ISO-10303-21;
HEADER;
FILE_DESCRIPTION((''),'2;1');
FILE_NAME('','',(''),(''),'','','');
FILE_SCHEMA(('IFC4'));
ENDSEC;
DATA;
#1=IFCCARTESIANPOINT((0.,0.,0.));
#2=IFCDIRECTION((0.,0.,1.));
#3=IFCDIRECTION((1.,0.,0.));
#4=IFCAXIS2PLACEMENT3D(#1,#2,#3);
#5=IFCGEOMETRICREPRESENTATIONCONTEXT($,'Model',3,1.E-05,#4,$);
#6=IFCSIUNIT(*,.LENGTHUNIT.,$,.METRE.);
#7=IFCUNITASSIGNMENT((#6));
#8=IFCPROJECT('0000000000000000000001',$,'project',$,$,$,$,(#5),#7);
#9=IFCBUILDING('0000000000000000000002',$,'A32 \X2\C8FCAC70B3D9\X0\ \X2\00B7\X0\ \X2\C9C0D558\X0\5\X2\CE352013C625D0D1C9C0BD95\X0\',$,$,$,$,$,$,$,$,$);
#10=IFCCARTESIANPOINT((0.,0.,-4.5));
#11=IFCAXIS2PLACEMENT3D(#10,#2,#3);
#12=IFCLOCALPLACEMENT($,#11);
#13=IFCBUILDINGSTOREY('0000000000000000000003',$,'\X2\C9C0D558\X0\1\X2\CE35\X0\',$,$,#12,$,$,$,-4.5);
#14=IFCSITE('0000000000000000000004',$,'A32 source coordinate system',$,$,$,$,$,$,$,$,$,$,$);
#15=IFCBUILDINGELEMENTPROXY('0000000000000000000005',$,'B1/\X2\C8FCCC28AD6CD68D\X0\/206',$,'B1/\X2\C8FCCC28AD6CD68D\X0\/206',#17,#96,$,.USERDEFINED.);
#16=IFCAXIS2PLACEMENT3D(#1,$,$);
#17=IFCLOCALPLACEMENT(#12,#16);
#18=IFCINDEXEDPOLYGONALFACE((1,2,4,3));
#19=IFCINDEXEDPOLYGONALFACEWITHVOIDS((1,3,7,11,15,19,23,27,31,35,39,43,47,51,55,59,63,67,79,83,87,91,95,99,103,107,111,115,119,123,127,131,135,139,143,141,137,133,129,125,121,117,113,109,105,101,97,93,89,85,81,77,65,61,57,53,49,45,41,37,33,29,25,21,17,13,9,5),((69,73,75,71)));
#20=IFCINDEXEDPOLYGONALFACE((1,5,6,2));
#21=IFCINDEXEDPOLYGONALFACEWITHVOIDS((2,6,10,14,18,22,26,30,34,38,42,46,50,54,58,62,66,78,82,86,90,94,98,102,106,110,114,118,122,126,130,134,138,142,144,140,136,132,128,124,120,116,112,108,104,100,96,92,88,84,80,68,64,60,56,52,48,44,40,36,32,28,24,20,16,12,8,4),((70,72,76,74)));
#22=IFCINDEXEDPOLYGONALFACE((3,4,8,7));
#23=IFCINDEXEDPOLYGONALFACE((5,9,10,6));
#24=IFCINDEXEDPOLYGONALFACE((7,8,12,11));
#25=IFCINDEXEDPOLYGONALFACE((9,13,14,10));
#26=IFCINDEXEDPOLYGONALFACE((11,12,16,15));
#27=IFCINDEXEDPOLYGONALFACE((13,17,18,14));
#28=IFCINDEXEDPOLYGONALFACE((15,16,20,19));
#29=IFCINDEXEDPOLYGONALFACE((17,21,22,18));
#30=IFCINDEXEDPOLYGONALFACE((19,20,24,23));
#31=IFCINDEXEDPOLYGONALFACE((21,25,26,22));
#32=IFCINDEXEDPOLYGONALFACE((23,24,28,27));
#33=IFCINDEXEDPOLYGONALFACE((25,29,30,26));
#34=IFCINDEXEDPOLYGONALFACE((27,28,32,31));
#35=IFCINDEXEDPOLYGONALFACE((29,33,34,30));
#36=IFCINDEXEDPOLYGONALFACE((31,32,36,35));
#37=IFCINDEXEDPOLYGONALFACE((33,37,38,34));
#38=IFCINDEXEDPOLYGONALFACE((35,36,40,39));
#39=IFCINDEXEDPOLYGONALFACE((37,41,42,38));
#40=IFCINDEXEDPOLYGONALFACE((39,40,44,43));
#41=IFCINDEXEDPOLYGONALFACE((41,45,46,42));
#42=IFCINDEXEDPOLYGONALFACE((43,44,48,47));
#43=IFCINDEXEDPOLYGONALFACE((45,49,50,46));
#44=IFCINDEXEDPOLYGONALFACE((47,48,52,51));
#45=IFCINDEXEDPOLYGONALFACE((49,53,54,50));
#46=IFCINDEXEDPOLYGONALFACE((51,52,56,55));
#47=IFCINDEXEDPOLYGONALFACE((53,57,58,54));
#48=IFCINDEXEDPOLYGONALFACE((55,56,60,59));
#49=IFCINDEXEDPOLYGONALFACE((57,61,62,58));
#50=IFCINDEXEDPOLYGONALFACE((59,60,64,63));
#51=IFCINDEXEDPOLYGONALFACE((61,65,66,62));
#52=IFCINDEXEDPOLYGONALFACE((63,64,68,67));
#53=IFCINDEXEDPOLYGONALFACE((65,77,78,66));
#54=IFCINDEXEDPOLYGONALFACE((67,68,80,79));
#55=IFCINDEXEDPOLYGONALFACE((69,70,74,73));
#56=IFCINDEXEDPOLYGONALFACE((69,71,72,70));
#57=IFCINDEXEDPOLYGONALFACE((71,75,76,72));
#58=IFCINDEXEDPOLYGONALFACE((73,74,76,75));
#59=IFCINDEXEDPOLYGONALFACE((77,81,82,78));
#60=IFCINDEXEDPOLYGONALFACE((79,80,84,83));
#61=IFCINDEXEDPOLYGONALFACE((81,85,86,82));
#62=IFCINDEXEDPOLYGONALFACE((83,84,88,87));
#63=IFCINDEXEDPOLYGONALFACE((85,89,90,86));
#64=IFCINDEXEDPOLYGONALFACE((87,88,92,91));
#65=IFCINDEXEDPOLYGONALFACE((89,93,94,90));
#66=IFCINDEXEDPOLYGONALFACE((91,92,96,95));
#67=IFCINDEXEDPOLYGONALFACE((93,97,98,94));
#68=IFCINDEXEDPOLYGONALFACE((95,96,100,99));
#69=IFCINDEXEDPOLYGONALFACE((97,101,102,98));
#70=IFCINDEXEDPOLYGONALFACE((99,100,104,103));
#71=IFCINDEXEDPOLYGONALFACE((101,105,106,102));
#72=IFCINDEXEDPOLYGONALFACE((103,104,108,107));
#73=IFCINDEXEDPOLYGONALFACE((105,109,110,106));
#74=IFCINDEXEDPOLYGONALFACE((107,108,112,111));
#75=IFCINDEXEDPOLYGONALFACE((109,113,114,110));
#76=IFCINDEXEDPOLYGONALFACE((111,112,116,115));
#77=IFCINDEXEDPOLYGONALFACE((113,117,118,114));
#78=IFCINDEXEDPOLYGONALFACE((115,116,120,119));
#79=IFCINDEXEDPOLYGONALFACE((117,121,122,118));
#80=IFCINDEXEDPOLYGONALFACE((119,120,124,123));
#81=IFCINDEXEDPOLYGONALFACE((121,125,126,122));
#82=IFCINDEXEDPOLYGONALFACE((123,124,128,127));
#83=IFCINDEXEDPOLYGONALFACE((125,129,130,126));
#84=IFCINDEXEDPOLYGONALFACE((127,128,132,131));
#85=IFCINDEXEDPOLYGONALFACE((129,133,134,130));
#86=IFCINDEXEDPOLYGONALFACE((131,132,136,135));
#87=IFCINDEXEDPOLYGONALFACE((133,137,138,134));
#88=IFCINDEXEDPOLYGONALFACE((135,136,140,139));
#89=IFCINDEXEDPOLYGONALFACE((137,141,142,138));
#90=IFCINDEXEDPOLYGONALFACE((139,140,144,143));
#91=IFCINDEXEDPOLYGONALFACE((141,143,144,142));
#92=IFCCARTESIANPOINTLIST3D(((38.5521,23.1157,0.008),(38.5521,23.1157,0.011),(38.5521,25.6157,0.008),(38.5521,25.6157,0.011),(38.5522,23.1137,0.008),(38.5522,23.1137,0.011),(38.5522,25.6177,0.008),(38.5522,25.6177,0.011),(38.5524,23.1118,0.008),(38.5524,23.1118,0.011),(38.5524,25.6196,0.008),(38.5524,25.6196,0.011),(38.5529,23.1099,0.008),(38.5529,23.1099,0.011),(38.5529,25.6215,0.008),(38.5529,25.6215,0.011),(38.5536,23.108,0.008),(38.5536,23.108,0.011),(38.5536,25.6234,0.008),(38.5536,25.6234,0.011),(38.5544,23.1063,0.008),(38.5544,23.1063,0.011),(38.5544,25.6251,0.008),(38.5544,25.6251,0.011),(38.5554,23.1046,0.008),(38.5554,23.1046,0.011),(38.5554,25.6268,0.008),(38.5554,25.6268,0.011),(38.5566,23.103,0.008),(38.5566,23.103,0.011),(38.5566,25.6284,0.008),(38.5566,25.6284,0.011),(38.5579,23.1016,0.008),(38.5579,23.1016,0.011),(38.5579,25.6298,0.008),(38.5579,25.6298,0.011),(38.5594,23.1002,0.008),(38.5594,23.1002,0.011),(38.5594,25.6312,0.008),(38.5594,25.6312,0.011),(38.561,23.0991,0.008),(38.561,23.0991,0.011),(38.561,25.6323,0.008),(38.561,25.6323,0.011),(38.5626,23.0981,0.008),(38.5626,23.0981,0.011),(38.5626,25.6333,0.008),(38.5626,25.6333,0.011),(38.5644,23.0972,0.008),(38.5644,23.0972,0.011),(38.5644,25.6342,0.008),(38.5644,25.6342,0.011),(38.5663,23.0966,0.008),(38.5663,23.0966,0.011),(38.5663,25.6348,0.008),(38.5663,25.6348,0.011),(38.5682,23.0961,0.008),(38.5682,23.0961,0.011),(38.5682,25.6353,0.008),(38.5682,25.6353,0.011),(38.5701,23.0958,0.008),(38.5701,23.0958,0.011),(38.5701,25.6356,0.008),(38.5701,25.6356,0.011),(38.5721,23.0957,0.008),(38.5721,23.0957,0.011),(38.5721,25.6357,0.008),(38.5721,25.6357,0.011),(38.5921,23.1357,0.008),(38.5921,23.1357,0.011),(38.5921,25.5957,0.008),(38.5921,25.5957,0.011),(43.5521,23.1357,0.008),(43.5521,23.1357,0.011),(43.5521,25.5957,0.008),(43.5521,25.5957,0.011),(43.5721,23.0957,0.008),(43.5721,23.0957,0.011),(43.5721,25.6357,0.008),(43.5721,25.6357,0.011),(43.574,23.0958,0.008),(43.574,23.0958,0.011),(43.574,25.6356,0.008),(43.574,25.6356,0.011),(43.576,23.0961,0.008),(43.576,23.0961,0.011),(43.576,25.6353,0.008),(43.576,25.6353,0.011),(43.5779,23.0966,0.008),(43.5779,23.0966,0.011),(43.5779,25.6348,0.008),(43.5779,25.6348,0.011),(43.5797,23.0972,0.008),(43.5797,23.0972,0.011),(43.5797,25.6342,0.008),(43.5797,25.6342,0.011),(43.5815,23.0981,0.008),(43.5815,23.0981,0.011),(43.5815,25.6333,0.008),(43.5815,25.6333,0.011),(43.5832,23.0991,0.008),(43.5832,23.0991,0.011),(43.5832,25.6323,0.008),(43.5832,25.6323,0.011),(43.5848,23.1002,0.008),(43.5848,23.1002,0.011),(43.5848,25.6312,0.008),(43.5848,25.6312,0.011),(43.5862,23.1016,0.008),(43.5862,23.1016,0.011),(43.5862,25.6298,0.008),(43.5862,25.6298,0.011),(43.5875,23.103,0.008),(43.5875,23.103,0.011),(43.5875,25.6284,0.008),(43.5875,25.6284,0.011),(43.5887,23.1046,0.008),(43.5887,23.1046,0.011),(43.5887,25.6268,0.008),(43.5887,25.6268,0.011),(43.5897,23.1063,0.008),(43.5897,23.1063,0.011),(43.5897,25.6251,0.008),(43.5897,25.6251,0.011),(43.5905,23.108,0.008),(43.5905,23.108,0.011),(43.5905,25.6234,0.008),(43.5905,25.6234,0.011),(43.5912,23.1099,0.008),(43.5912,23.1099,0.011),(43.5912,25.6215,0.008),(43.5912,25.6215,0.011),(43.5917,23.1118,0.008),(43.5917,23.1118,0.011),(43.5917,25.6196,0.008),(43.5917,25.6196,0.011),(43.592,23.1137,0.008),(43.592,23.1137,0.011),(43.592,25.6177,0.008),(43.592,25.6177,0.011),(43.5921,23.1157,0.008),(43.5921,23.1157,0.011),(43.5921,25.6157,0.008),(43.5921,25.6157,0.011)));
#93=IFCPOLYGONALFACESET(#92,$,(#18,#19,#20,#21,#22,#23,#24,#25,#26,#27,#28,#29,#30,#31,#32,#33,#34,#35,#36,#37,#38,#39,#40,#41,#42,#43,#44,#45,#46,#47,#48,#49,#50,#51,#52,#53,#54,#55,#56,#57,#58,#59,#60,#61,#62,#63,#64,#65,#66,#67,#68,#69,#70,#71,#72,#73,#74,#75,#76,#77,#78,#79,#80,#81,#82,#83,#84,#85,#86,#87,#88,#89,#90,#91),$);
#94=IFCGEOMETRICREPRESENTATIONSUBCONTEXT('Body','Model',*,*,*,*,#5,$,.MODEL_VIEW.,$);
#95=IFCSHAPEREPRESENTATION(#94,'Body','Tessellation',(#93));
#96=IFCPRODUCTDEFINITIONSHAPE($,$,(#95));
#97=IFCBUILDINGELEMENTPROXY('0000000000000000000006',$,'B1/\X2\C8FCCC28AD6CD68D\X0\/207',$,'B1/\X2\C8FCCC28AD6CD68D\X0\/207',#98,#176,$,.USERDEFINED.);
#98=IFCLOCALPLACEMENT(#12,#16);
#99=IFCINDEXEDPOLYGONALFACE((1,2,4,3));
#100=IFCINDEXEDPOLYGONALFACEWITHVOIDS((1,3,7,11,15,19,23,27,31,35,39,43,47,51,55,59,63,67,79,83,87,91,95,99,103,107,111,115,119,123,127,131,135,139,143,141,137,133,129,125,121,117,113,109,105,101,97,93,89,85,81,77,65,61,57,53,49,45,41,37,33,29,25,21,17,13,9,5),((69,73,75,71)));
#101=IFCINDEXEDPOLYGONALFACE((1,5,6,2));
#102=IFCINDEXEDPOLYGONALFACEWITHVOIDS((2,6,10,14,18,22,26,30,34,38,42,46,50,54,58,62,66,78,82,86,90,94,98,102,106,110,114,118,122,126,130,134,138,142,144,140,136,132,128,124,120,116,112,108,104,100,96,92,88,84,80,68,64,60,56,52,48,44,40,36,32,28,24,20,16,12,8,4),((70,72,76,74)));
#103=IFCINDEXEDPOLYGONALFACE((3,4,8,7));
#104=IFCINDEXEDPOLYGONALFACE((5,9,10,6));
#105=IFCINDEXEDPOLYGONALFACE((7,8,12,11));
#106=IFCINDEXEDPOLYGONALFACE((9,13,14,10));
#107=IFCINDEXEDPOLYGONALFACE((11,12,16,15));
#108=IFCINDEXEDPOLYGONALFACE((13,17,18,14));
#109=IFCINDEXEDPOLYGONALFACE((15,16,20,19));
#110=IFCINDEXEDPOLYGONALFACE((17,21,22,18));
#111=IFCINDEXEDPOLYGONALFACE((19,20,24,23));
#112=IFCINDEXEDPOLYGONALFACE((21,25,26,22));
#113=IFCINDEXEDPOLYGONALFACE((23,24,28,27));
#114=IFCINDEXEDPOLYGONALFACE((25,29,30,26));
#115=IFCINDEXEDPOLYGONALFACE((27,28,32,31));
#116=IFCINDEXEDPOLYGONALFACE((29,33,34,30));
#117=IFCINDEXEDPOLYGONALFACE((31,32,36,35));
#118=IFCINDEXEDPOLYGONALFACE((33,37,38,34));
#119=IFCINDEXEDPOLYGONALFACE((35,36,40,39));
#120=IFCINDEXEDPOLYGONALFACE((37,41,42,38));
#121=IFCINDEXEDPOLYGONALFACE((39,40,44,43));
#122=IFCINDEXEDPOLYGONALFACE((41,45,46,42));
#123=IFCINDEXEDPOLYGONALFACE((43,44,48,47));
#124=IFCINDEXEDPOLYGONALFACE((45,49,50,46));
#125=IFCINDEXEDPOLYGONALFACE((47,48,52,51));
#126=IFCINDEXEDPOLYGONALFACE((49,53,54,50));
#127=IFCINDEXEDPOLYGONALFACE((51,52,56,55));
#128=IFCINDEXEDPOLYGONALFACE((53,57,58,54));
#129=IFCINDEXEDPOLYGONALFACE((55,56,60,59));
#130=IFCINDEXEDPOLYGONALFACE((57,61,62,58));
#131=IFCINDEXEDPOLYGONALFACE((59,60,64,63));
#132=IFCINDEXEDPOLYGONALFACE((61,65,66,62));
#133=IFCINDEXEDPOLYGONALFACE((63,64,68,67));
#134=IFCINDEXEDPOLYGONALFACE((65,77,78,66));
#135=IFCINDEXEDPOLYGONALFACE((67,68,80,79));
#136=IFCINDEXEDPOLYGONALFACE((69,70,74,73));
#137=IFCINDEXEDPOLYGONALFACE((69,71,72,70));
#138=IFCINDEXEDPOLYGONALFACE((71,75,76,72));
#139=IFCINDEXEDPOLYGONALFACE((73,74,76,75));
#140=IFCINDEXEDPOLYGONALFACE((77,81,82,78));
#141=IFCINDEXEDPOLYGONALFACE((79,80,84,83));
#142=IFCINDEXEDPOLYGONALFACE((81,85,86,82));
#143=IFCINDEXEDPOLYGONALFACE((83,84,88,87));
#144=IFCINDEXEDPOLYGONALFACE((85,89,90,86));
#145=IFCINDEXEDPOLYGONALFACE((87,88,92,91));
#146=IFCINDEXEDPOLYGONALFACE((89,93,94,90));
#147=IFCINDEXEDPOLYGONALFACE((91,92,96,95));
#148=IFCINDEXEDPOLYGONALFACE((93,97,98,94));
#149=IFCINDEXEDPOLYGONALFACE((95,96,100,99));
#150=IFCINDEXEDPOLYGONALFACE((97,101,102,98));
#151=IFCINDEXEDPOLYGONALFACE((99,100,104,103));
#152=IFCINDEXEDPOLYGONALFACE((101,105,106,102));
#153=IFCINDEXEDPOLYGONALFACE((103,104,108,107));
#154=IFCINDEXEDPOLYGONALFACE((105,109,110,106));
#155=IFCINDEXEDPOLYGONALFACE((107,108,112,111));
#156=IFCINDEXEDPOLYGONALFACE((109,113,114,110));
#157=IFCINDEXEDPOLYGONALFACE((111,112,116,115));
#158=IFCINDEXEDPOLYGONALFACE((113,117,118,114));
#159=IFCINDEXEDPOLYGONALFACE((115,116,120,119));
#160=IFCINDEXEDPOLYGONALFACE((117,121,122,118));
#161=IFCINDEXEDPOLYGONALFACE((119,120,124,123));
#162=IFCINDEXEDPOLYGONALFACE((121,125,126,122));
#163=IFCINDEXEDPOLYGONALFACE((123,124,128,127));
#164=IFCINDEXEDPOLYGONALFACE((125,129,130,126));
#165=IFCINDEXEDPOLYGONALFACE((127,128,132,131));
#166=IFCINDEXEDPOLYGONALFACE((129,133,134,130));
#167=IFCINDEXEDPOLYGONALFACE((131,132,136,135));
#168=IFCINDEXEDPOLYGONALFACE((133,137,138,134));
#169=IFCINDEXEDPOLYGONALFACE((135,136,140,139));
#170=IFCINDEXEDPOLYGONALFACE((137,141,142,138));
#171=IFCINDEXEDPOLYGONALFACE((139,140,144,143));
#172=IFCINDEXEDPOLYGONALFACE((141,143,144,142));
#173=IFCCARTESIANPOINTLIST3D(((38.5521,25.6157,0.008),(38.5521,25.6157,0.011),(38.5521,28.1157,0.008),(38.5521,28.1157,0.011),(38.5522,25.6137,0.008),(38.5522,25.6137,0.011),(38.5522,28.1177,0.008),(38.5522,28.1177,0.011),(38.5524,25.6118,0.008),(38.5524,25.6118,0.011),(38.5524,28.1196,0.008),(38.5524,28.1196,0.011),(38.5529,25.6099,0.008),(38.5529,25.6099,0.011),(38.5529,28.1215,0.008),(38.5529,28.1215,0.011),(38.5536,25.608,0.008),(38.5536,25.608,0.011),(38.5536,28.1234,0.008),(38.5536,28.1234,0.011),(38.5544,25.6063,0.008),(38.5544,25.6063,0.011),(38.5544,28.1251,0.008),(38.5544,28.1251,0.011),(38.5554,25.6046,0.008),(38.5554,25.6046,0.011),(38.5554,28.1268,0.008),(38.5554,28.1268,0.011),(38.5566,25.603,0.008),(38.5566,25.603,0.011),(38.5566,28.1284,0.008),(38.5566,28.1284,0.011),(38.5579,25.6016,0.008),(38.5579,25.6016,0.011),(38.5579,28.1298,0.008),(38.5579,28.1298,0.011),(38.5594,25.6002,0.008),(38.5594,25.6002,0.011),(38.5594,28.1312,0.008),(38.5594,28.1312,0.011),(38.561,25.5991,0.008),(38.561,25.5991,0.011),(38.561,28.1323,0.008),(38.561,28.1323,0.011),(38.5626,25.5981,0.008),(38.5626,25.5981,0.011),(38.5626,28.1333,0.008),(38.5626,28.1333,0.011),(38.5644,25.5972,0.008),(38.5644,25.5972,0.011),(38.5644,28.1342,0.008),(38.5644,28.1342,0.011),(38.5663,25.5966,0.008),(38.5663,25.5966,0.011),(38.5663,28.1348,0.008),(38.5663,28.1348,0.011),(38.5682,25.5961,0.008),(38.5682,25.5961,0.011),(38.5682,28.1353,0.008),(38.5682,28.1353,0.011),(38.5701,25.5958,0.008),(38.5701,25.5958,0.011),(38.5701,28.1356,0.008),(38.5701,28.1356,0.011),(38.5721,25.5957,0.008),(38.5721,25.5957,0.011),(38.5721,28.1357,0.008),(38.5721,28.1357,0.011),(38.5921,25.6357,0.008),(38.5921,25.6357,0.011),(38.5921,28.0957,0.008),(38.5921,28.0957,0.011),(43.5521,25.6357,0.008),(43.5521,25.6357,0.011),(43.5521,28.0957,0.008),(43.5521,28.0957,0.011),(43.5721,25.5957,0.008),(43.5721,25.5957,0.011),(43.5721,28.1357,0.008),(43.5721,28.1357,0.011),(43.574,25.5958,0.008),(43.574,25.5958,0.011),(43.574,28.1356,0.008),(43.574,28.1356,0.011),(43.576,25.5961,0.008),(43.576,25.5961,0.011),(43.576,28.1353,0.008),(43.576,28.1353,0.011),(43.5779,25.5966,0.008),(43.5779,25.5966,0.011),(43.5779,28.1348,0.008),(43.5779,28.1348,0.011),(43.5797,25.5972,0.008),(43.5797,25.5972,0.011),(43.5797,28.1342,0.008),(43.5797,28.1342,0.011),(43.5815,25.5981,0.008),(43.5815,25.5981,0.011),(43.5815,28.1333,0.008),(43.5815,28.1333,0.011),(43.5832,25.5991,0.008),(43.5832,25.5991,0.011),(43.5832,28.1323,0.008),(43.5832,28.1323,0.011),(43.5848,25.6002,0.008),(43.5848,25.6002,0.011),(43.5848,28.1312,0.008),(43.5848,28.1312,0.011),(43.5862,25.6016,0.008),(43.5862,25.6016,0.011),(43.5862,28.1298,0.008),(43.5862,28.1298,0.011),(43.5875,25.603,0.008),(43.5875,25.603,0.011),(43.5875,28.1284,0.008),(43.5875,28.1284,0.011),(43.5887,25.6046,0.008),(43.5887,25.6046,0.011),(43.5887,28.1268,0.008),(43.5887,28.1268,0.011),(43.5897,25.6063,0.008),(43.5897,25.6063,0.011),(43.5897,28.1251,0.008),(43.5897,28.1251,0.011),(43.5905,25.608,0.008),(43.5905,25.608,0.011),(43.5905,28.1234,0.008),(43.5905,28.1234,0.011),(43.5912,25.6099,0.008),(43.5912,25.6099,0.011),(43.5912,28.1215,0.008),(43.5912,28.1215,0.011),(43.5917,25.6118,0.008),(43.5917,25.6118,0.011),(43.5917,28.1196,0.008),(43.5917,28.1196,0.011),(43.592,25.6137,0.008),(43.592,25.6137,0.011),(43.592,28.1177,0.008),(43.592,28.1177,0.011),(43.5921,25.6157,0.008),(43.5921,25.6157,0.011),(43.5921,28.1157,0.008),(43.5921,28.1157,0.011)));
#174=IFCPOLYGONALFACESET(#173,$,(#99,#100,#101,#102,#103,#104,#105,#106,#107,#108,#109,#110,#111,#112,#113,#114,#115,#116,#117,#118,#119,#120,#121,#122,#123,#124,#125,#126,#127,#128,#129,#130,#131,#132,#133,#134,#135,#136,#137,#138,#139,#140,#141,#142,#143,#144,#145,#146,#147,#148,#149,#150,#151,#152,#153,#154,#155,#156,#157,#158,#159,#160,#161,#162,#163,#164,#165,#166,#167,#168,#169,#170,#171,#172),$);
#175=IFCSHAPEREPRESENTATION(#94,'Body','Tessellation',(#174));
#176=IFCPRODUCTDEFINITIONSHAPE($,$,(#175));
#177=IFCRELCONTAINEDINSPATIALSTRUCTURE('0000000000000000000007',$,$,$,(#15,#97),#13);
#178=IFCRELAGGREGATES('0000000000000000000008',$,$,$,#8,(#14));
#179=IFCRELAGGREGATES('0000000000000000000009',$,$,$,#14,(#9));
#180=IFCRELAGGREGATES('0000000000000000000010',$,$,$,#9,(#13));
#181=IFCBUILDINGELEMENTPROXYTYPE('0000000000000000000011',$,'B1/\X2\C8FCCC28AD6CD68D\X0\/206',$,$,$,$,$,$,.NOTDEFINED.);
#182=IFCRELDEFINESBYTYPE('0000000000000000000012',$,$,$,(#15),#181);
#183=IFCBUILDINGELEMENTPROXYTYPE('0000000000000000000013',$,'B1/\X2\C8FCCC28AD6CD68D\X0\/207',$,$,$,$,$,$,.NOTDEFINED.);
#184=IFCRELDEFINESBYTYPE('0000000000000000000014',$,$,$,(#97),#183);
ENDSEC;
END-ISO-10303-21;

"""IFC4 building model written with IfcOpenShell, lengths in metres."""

from ifc_helpers import new_model, si_unit, frame, origin, origin_with_axes, place, context, subcontext, project, spatial, polyline, outline, extrude, source, transform, mapped, type_object, type_shapes, element, save


model = new_model("IFC4")

# Units and contexts
model_context = context("Model", 3, precision=1e-05, world=origin_with_axes())
body_context = subcontext(model_context, "Body", "Model", "MODEL_VIEW")
ifc_project = project(units=[si_unit("LENGTHUNIT", "METRE")], contexts=[model_context])

# Site, building, storey
site = spatial("IfcSite", under=ifc_project, Name="A32 source coordinate system")
building = spatial("IfcBuilding", under=site, Name="A32 주거동 · 지하5층–옥탑지붕")
storey_placement = place(None, frame((0.0, 0.0, -4.5), z_axis=(0.0, 0.0, 1.0), x_axis=(1.0, 0.0, 0.0)))
storey = spatial("IfcBuildingStorey", under=building, at=storey_placement, Name="지하1층", Elevation=-4.5)

# Building element proxies
building_element_proxy_type_1 = type_object("IfcBuildingElementProxyType", Name="B1/주차구획/206", PredefinedType="NOTDEFINED")
shared_shape_1 = source(origin(), body_context, "Body", "SweptSolid", [
    extrude(outline(polyline([(43.5721, 25.6357), (43.574, 25.6356), (43.576, 25.6353), (43.5779, 25.6348), (43.5797, 25.6342), (43.5815, 25.6333), (43.5832, 25.6323), (43.5848, 25.6312), (43.5862, 25.6298), (43.5875, 25.6284), (43.5887, 25.6268), (43.5897, 25.6251), (43.5905, 25.6234), (43.5912, 25.6215), (43.5917, 25.6196), (43.592, 25.6177), (43.5921, 25.6157), (43.5921, 23.1157), (43.592, 23.1137), (43.5917, 23.1118), (43.5912, 23.1099), (43.5905, 23.108), (43.5897, 23.1063), (43.5887, 23.1046), (43.5875, 23.103), (43.5862, 23.1016), (43.5848, 23.1002), (43.5832, 23.0991), (43.5815, 23.0981), (43.5797, 23.0972), (43.5779, 23.0966), (43.576, 23.0961), (43.574, 23.0958), (43.5721, 23.0957), (38.5721, 23.0957), (38.5701, 23.0958), (38.5682, 23.0961), (38.5663, 23.0966), (38.5644, 23.0972), (38.5626, 23.0981), (38.561, 23.0991), (38.5594, 23.1002), (38.5579, 23.1016), (38.5566, 23.103), (38.5554, 23.1046), (38.5544, 23.1063), (38.5536, 23.108), (38.5529, 23.1099), (38.5524, 23.1118), (38.5522, 23.1137), (38.5521, 23.1157), (38.5521, 25.6157), (38.5522, 25.6177), (38.5524, 25.6196), (38.5529, 25.6215), (38.5536, 25.6234), (38.5544, 25.6251), (38.5554, 25.6268), (38.5566, 25.6284), (38.5579, 25.6298), (38.5594, 25.6312), (38.561, 25.6323), (38.5626, 25.6333), (38.5644, 25.6342), (38.5663, 25.6348), (38.5682, 25.6353), (38.5701, 25.6356), (38.5721, 25.6357), (43.5721, 25.6357)]), holes=[polyline([(43.5521, 25.5957), (38.5921, 25.5957), (38.5921, 23.1357), (43.5521, 23.1357), (43.5521, 25.5957)])]), frame((0.0, 0.0, 0.008)), (0.0, 0.0, 1.0), 0.003),
])
type_shapes(building_element_proxy_type_1, [shared_shape_1])
proxy_1_placement = place(storey_placement, origin_with_axes())
element("IfcBuildingElementProxy", 1, at=proxy_1_placement, inside=storey, type_object=building_element_proxy_type_1, Name="B1/주차구획/206", ObjectType="B1/주차구획/206", PredefinedType="USERDEFINED", context=body_context, shape_type="MappedRepresentation", body=[
    mapped(shared_shape_1, transform((0.0, 0.0, 0.0), scale=1.0)),
])
building_element_proxy_type_2 = type_object("IfcBuildingElementProxyType", Name="B1/주차구획/207", PredefinedType="NOTDEFINED")
shared_shape_2 = source(origin(), body_context, "Body", "SweptSolid", [
    extrude(outline(polyline([(43.5721, 28.1357), (43.574, 28.1356), (43.576, 28.1353), (43.5779, 28.1348), (43.5797, 28.1342), (43.5815, 28.1333), (43.5832, 28.1323), (43.5848, 28.1312), (43.5862, 28.1298), (43.5875, 28.1284), (43.5887, 28.1268), (43.5897, 28.1251), (43.5905, 28.1234), (43.5912, 28.1215), (43.5917, 28.1196), (43.592, 28.1177), (43.5921, 28.1157), (43.5921, 25.6157), (43.592, 25.6137), (43.5917, 25.6118), (43.5912, 25.6099), (43.5905, 25.608), (43.5897, 25.6063), (43.5887, 25.6046), (43.5875, 25.603), (43.5862, 25.6016), (43.5848, 25.6002), (43.5832, 25.5991), (43.5815, 25.5981), (43.5797, 25.5972), (43.5779, 25.5966), (43.576, 25.5961), (43.574, 25.5958), (43.5721, 25.5957), (38.5721, 25.5957), (38.5701, 25.5958), (38.5682, 25.5961), (38.5663, 25.5966), (38.5644, 25.5972), (38.5626, 25.5981), (38.561, 25.5991), (38.5594, 25.6002), (38.5579, 25.6016), (38.5566, 25.603), (38.5554, 25.6046), (38.5544, 25.6063), (38.5536, 25.608), (38.5529, 25.6099), (38.5524, 25.6118), (38.5522, 25.6137), (38.5521, 25.6157), (38.5521, 28.1157), (38.5522, 28.1177), (38.5524, 28.1196), (38.5529, 28.1215), (38.5536, 28.1234), (38.5544, 28.1251), (38.5554, 28.1268), (38.5566, 28.1284), (38.5579, 28.1298), (38.5594, 28.1312), (38.561, 28.1323), (38.5626, 28.1333), (38.5644, 28.1342), (38.5663, 28.1348), (38.5682, 28.1353), (38.5701, 28.1356), (38.5721, 28.1357), (43.5721, 28.1357)]), holes=[polyline([(43.5521, 28.0957), (38.5921, 28.0957), (38.5921, 25.6357), (43.5521, 25.6357), (43.5521, 28.0957)])]), frame((0.0, 0.0, 0.008)), (0.0, 0.0, 1.0), 0.003),
])
type_shapes(building_element_proxy_type_2, [shared_shape_2])
proxy_2_placement = place(storey_placement, origin_with_axes())
element("IfcBuildingElementProxy", 2, at=proxy_2_placement, inside=storey, type_object=building_element_proxy_type_2, Name="B1/주차구획/207", ObjectType="B1/주차구획/207", PredefinedType="USERDEFINED", context=body_context, shape_type="MappedRepresentation", body=[
    mapped(shared_shape_2, transform((0.0, 0.0, 0.0), scale=1.0)),
])

save(model, "model.ifc")
